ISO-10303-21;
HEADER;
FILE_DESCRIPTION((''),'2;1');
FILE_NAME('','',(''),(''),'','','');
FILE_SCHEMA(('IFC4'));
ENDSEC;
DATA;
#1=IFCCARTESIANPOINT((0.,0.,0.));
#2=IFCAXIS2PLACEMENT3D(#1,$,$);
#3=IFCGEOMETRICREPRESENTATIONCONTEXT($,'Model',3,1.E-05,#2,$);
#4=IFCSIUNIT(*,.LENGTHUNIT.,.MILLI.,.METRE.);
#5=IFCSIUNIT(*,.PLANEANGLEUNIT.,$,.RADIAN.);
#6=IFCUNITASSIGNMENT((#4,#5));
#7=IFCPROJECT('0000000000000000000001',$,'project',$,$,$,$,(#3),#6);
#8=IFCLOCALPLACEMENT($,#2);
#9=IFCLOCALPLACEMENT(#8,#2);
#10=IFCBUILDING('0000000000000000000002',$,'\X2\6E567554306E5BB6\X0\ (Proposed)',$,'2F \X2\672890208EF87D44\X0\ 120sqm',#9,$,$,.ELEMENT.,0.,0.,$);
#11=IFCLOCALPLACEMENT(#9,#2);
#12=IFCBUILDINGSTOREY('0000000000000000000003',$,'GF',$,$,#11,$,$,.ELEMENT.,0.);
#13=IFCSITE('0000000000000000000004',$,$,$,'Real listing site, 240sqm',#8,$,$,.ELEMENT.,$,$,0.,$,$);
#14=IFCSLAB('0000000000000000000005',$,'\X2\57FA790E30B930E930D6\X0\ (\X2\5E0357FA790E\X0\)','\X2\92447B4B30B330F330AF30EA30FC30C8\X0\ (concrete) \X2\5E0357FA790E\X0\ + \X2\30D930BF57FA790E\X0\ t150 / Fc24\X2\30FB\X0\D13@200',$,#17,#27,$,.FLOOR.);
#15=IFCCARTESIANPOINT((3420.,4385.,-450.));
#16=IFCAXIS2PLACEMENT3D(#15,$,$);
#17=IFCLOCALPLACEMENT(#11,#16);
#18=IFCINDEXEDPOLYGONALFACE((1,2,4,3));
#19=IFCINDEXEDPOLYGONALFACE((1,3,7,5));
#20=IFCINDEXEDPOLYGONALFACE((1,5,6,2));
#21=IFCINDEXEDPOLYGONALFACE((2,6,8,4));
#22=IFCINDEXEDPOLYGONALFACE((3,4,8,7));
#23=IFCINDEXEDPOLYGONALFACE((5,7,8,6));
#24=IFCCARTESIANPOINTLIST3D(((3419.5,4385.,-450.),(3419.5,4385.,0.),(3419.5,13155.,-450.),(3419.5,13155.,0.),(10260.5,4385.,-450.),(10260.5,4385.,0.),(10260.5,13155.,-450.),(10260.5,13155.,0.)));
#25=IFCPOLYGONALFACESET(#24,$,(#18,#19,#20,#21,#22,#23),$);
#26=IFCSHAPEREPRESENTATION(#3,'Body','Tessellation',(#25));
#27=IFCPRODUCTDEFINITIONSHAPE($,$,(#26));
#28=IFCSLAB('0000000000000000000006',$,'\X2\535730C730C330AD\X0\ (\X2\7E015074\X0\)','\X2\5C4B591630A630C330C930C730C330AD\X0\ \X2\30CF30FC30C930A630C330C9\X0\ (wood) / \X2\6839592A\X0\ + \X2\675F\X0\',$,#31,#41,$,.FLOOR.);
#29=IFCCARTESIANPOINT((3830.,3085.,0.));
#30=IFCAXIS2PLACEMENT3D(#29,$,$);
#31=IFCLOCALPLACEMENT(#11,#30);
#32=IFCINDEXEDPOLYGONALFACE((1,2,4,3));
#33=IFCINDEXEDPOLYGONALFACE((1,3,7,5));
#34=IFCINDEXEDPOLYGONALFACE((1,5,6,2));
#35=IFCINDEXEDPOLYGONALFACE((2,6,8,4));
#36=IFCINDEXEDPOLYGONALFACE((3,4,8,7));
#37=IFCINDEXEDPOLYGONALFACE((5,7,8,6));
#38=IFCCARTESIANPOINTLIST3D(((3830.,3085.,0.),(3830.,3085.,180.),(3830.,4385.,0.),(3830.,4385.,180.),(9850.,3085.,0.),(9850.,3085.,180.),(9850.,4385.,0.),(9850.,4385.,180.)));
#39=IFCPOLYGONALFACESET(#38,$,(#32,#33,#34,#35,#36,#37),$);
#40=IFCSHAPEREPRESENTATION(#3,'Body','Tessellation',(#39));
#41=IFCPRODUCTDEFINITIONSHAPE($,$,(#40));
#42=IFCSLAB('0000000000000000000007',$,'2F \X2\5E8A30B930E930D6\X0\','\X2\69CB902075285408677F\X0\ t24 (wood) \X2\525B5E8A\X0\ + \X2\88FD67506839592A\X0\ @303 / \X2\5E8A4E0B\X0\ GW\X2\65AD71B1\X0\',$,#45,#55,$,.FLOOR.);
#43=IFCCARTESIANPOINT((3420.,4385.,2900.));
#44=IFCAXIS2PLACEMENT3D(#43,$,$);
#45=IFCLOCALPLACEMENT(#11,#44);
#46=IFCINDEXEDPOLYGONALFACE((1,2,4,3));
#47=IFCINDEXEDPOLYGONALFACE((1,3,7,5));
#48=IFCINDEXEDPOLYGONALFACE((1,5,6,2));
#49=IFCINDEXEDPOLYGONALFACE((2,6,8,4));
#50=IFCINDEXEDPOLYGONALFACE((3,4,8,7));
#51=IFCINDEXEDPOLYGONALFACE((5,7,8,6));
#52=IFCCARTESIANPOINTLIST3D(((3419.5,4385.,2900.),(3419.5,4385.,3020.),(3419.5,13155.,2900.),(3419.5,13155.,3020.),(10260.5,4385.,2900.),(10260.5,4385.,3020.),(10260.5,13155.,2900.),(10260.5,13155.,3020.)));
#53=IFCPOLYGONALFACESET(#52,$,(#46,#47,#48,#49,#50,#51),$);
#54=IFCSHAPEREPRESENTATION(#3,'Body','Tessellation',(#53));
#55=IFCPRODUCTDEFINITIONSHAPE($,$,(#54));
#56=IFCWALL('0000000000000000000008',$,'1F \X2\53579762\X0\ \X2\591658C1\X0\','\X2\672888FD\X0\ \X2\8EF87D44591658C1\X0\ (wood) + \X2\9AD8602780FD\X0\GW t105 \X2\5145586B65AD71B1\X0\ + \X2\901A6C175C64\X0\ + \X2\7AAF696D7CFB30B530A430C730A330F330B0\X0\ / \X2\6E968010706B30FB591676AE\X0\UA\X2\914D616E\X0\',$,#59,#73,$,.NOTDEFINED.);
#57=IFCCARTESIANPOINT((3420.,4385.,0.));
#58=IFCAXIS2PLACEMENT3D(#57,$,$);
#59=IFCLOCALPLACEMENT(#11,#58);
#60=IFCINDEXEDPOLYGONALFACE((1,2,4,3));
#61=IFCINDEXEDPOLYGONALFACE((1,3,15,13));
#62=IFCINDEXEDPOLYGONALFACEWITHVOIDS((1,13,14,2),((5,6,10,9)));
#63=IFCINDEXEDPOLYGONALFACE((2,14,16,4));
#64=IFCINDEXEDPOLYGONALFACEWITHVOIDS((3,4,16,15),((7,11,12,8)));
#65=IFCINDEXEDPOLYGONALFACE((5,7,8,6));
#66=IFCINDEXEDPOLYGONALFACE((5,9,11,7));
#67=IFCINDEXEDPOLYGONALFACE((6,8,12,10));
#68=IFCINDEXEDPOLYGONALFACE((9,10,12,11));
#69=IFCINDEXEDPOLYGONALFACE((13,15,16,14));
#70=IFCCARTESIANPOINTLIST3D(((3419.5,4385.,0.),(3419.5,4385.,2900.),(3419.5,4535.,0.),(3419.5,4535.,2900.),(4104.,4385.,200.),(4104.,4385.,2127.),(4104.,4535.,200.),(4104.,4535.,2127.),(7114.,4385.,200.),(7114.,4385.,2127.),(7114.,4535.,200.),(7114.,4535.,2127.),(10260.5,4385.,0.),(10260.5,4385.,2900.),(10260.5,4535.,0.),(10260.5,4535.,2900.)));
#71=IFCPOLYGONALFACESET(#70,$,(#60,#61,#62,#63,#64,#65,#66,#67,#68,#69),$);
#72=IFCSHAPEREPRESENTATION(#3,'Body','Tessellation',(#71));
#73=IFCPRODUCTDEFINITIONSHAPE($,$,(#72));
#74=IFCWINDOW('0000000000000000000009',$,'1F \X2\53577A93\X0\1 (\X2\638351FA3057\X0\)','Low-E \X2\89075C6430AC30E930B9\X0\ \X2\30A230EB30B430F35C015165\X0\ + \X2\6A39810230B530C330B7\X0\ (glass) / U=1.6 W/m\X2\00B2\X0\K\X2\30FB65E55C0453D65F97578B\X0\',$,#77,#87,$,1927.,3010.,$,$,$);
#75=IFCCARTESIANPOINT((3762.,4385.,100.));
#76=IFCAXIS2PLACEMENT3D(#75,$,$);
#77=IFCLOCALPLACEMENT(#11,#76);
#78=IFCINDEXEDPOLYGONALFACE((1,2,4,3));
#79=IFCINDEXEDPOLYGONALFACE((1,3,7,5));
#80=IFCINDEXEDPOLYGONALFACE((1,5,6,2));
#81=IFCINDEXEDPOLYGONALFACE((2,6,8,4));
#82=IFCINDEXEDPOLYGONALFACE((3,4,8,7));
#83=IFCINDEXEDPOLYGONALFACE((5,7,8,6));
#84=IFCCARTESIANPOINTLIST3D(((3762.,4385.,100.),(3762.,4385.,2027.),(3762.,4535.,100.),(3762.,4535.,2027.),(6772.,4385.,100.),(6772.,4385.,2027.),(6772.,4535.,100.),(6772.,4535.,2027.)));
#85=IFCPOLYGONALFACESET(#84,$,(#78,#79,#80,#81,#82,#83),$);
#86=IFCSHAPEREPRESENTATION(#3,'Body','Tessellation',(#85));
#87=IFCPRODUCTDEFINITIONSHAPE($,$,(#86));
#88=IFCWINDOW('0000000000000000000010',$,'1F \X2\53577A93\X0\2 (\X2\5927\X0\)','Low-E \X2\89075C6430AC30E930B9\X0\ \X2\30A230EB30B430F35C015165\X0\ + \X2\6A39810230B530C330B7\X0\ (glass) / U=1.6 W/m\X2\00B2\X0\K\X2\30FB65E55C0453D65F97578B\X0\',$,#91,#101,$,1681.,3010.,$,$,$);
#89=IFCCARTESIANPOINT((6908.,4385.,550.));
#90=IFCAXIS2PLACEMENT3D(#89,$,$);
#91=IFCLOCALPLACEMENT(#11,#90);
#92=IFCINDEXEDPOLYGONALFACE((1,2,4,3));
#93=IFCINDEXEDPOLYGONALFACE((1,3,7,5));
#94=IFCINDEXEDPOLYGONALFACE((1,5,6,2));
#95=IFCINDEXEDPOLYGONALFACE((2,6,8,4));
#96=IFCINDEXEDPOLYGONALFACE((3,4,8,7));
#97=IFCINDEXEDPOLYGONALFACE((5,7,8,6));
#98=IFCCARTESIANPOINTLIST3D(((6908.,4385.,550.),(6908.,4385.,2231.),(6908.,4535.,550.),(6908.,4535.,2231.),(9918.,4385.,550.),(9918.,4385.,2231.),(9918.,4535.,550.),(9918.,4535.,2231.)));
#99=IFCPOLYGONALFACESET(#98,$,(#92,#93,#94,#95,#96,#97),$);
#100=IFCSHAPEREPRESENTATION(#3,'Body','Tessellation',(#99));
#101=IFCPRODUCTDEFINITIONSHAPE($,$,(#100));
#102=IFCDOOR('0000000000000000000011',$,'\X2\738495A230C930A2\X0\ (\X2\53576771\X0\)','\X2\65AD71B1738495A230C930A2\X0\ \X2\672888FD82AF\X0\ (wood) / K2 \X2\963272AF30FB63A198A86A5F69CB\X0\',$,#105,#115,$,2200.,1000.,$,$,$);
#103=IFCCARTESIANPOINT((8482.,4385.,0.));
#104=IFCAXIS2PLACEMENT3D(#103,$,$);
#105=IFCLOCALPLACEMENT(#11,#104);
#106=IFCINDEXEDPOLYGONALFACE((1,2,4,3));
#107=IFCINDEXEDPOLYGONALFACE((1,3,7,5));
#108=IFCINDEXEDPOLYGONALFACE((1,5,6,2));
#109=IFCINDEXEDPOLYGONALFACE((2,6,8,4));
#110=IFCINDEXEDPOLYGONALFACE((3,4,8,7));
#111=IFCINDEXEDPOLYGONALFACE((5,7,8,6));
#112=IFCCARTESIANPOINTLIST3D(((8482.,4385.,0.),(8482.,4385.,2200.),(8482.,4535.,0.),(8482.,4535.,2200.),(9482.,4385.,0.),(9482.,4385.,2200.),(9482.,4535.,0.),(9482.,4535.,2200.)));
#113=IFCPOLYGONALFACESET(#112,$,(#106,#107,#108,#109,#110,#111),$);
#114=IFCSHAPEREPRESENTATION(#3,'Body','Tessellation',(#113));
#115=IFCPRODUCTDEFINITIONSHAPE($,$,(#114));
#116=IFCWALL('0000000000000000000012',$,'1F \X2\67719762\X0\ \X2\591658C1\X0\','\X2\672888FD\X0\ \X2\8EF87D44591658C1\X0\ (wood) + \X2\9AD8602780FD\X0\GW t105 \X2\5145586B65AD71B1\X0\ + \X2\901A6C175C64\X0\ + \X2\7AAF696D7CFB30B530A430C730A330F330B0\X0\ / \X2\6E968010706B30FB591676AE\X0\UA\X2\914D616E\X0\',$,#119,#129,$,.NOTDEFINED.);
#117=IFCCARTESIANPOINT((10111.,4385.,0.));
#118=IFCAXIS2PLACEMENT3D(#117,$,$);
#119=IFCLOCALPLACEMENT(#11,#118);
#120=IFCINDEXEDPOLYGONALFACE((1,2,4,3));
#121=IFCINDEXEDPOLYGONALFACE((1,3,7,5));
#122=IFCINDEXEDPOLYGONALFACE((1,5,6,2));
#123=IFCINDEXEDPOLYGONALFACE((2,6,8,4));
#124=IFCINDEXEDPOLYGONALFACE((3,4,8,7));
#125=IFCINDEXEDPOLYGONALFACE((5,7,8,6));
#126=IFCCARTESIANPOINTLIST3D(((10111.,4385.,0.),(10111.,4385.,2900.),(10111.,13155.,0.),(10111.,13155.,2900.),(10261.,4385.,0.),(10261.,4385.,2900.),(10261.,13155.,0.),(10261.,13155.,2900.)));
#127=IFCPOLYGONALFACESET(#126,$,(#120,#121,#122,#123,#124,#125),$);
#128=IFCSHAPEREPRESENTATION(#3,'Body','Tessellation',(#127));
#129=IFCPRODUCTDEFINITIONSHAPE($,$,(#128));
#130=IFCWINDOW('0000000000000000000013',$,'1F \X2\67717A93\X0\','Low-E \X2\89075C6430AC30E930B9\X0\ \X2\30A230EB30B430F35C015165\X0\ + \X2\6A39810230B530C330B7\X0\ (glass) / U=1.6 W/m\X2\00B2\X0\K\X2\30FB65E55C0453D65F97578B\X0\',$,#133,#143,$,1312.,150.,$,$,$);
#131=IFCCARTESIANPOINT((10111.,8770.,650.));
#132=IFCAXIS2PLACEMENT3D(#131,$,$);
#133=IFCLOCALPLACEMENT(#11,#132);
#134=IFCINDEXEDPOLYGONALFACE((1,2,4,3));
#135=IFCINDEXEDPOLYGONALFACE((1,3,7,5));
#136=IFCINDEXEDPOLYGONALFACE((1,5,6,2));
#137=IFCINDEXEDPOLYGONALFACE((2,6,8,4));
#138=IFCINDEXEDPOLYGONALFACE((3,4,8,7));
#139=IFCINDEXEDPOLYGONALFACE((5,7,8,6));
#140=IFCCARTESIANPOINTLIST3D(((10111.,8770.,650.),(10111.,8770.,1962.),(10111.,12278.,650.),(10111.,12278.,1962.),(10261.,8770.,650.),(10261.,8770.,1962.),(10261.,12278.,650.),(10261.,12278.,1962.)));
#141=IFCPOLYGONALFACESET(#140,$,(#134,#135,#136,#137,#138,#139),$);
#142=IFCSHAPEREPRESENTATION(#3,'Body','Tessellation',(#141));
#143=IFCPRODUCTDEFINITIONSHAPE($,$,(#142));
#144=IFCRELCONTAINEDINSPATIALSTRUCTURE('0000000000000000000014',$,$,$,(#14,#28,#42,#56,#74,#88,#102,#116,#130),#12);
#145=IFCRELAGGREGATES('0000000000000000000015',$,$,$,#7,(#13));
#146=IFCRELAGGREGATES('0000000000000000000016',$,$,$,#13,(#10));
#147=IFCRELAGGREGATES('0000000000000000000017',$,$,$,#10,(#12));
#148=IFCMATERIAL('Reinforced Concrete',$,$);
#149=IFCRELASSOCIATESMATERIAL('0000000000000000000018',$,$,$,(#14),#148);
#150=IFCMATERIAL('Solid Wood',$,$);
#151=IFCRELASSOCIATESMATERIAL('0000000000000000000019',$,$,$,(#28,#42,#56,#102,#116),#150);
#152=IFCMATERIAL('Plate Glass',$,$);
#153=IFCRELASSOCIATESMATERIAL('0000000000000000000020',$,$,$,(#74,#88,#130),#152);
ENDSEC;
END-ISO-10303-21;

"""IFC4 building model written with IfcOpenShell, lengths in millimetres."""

from ifc_helpers import new_model, si_unit, frame, frame_2d, origin, place, context, project, spatial, rectangle, extrude, material, element, fill, save


model = new_model("IFC4")

# Units and contexts
model_context = context("Model", 3, precision=1e-05, world=origin())
ifc_project = project(units=[si_unit("LENGTHUNIT", "METRE", prefix="MILLI"), si_unit("PLANEANGLEUNIT", "RADIAN")], contexts=[model_context])

# Site, building, storey
site_placement = place(None, origin())
site = spatial("IfcSite", under=ifc_project, at=site_placement, ObjectType="Real listing site, 240sqm", CompositionType="ELEMENT", RefElevation=0.0)
building_placement = place(site_placement, origin())
building = spatial("IfcBuilding", under=site, at=building_placement, Name="湖畔の家 (Proposed)", ObjectType="2F 木造軸組 120sqm", CompositionType="ELEMENT", ElevationOfRefHeight=0.0, ElevationOfTerrain=0.0)
storey_placement = place(building_placement, origin())
storey = spatial("IfcBuildingStorey", under=building, at=storey_placement, Name="GF", CompositionType="ELEMENT", Elevation=0.0)

# Slabs
ifc_material_1 = material(Name="Reinforced Concrete")
slab_1_placement = place(storey_placement, frame((3420.0, 4385.0, -450.0)))
element("IfcSlab", 1, at=slab_1_placement, inside=storey, material=ifc_material_1, Name="基礎スラブ (布基礎)", Description="鉄筋コンクリート (concrete) 布基礎 + ベタ基礎 t150 / Fc24・D13@200", PredefinedType="FLOOR", context=model_context, shape_type="SweptSolid", body=[
    extrude(rectangle(XDim=6841.0, YDim=8770.0, at=frame_2d((3420.0, 4385.0))), frame((3420.0, 4385.0, -450.0)), (0.0, 0.0, 1.0), 450.0),
])
ifc_material_2 = material(Name="Solid Wood")
slab_2_placement = place(storey_placement, frame((3830.0, 3085.0, 0.0)))
element("IfcSlab", 2, at=slab_2_placement, inside=storey, material=ifc_material_2, Name="南デッキ (縁側)", Description="屋外ウッドデッキ ハードウッド (wood) / 根太 + 束", PredefinedType="FLOOR", context=model_context, shape_type="SweptSolid", body=[
    extrude(rectangle(XDim=6020.0, YDim=1300.0, at=frame_2d((3010.0, 650.0))), frame((3830.0, 3085.0, 0.0)), (0.0, 0.0, 1.0), 180.0),
])
slab_3_placement = place(storey_placement, frame((3420.0, 4385.0, 2900.0)))
element("IfcSlab", 3, at=slab_3_placement, inside=storey, material=ifc_material_2, Name="2F 床スラブ", Description="構造用合板 t24 (wood) 剛床 + 製材根太 @303 / 床下 GW断熱", PredefinedType="FLOOR", context=model_context, shape_type="SweptSolid", body=[
    extrude(rectangle(XDim=6841.0, YDim=8770.0, at=frame_2d((3420.0, 4385.0))), frame((3420.0, 4385.0, 2900.0)), (0.0, 0.0, 1.0), 120.0),
])

# Wall, openings, windows, door
wall_1_placement = place(storey_placement, frame((3420.0, 4385.0, 0.0)))
wall_1 = element("IfcWall", 4, at=wall_1_placement, inside=storey, material=ifc_material_2, Name="1F 南面 外壁", Description="木製 軸組外壁 (wood) + 高性能GW t105 充填断熱 + 通気層 + 窯業系サイディング / 準耐火・外皮UA配慮", PredefinedType="NOTDEFINED", context=model_context, shape_type="SweptSolid", body=[
    extrude(rectangle(XDim=6841.0, YDim=150.0, at=frame_2d((3420.0, 75.0))), frame((3420.0, 4385.0, 0.0)), (0.0, 0.0, 1.0), 2900.0),
])
opening_1_placement = place(storey_placement, frame((3762.0, 4385.0, 100.0)))
opening_1 = element("IfcOpeningElement", 5, at=opening_1_placement, cuts=wall_1, PredefinedType="NOTDEFINED", context=model_context, shape_type="SweptSolid", body=[
    extrude(rectangle(XDim=3010.0, YDim=150.0, at=frame_2d((1505.0, 75.0))), frame((3762.0, 4385.0, 100.0)), (0.0, 0.0, 1.0), 1927.0),
])
opening_2_placement = place(storey_placement, frame((6908.0, 4385.0, 550.0)))
opening_2 = element("IfcOpeningElement", 6, at=opening_2_placement, cuts=wall_1, PredefinedType="NOTDEFINED", context=model_context, shape_type="SweptSolid", body=[
    extrude(rectangle(XDim=3010.0, YDim=150.0, at=frame_2d((1505.0, 75.0))), frame((6908.0, 4385.0, 550.0)), (0.0, 0.0, 1.0), 1681.0),
])
opening_3_placement = place(storey_placement, frame((8482.0, 4385.0, 0.0)))
opening_3 = element("IfcOpeningElement", 7, at=opening_3_placement, cuts=wall_1, PredefinedType="NOTDEFINED", context=model_context, shape_type="SweptSolid", body=[
    extrude(rectangle(XDim=1000.0, YDim=150.0, at=frame_2d((500.0, 75.0))), frame((8482.0, 4385.0, 0.0)), (0.0, 0.0, 1.0), 2200.0),
])
ifc_material_3 = material(Name="Plate Glass")
window_1_placement = place(storey_placement, frame((3762.0, 4385.0, 100.0)))
window_1 = element("IfcWindow", 8, at=window_1_placement, inside=storey, material=ifc_material_3, Name="1F 南窓1 (掃出し)", Description="Low-E 複層ガラス アルゴン封入 + 樹脂サッシ (glass) / U=1.6 W/m²K・日射取得型", OverallHeight=1927.0, OverallWidth=3010.0, context=model_context, shape_type="SweptSolid", body=[
    extrude(rectangle(XDim=3010.0, YDim=150.0, at=frame_2d((1505.0, 75.0))), frame((3762.0, 4385.0, 100.0)), (0.0, 0.0, 1.0), 1927.0),
])
fill(opening_1, window_1)
window_2_placement = place(storey_placement, frame((6908.0, 4385.0, 550.0)))
window_2 = element("IfcWindow", 9, at=window_2_placement, inside=storey, material=ifc_material_3, Name="1F 南窓2 (大)", Description="Low-E 複層ガラス アルゴン封入 + 樹脂サッシ (glass) / U=1.6 W/m²K・日射取得型", OverallHeight=1681.0, OverallWidth=3010.0, context=model_context, shape_type="SweptSolid", body=[
    extrude(rectangle(XDim=3010.0, YDim=150.0, at=frame_2d((1505.0, 75.0))), frame((6908.0, 4385.0, 550.0)), (0.0, 0.0, 1.0), 1681.0),
])
fill(opening_2, window_2)
door_placement = place(storey_placement, frame((8482.0, 4385.0, 0.0)))
door = element("IfcDoor", 10, at=door_placement, inside=storey, material=ifc_material_2, Name="玄関ドア (南東)", Description="断熱玄関ドア 木製芯 (wood) / K2 防犯・採風機構", OverallHeight=2200.0, OverallWidth=1000.0, context=model_context, shape_type="SweptSolid", body=[
    extrude(rectangle(XDim=1000.0, YDim=150.0, at=frame_2d((500.0, 75.0))), frame((8482.0, 4385.0, 0.0)), (0.0, 0.0, 1.0), 2200.0),
])
fill(opening_3, door)

# Wall, opening, window
wall_2_placement = place(storey_placement, frame((10111.0, 4385.0, 0.0)))
wall_2 = element("IfcWall", 11, at=wall_2_placement, inside=storey, material=ifc_material_2, Name="1F 東面 外壁", Description="木製 軸組外壁 (wood) + 高性能GW t105 充填断熱 + 通気層 + 窯業系サイディング / 準耐火・外皮UA配慮", PredefinedType="NOTDEFINED", context=model_context, shape_type="SweptSolid", body=[
    extrude(rectangle(XDim=150.0, YDim=8770.0, at=frame_2d((75.0, 4385.0))), frame((10111.0, 4385.0, 0.0)), (0.0, 0.0, 1.0), 2900.0),
])
opening_4_placement = place(storey_placement, frame((10111.0, 8770.0, 650.0)))
opening_4 = element("IfcOpeningElement", 12, at=opening_4_placement, cuts=wall_2, PredefinedType="NOTDEFINED", context=model_context, shape_type="SweptSolid", body=[
    extrude(rectangle(XDim=150.0, YDim=3508.0, at=frame_2d((75.0, 1754.0))), frame((10111.0, 8770.0, 650.0)), (0.0, 0.0, 1.0), 1312.0),
])
window_3_placement = place(storey_placement, frame((10111.0, 8770.0, 650.0)))
window_3 = element("IfcWindow", 13, at=window_3_placement, inside=storey, material=ifc_material_3, Name="1F 東窓", Description="Low-E 複層ガラス アルゴン封入 + 樹脂サッシ (glass) / U=1.6 W/m²K・日射取得型", OverallHeight=1312.0, OverallWidth=150.0, context=model_context, shape_type="SweptSolid", body=[
    extrude(rectangle(XDim=150.0, YDim=3508.0, at=frame_2d((75.0, 1754.0))), frame((10111.0, 8770.0, 650.0)), (0.0, 0.0, 1.0), 1312.0),
])
fill(opening_4, window_3)

save(model, "model.ifc")
